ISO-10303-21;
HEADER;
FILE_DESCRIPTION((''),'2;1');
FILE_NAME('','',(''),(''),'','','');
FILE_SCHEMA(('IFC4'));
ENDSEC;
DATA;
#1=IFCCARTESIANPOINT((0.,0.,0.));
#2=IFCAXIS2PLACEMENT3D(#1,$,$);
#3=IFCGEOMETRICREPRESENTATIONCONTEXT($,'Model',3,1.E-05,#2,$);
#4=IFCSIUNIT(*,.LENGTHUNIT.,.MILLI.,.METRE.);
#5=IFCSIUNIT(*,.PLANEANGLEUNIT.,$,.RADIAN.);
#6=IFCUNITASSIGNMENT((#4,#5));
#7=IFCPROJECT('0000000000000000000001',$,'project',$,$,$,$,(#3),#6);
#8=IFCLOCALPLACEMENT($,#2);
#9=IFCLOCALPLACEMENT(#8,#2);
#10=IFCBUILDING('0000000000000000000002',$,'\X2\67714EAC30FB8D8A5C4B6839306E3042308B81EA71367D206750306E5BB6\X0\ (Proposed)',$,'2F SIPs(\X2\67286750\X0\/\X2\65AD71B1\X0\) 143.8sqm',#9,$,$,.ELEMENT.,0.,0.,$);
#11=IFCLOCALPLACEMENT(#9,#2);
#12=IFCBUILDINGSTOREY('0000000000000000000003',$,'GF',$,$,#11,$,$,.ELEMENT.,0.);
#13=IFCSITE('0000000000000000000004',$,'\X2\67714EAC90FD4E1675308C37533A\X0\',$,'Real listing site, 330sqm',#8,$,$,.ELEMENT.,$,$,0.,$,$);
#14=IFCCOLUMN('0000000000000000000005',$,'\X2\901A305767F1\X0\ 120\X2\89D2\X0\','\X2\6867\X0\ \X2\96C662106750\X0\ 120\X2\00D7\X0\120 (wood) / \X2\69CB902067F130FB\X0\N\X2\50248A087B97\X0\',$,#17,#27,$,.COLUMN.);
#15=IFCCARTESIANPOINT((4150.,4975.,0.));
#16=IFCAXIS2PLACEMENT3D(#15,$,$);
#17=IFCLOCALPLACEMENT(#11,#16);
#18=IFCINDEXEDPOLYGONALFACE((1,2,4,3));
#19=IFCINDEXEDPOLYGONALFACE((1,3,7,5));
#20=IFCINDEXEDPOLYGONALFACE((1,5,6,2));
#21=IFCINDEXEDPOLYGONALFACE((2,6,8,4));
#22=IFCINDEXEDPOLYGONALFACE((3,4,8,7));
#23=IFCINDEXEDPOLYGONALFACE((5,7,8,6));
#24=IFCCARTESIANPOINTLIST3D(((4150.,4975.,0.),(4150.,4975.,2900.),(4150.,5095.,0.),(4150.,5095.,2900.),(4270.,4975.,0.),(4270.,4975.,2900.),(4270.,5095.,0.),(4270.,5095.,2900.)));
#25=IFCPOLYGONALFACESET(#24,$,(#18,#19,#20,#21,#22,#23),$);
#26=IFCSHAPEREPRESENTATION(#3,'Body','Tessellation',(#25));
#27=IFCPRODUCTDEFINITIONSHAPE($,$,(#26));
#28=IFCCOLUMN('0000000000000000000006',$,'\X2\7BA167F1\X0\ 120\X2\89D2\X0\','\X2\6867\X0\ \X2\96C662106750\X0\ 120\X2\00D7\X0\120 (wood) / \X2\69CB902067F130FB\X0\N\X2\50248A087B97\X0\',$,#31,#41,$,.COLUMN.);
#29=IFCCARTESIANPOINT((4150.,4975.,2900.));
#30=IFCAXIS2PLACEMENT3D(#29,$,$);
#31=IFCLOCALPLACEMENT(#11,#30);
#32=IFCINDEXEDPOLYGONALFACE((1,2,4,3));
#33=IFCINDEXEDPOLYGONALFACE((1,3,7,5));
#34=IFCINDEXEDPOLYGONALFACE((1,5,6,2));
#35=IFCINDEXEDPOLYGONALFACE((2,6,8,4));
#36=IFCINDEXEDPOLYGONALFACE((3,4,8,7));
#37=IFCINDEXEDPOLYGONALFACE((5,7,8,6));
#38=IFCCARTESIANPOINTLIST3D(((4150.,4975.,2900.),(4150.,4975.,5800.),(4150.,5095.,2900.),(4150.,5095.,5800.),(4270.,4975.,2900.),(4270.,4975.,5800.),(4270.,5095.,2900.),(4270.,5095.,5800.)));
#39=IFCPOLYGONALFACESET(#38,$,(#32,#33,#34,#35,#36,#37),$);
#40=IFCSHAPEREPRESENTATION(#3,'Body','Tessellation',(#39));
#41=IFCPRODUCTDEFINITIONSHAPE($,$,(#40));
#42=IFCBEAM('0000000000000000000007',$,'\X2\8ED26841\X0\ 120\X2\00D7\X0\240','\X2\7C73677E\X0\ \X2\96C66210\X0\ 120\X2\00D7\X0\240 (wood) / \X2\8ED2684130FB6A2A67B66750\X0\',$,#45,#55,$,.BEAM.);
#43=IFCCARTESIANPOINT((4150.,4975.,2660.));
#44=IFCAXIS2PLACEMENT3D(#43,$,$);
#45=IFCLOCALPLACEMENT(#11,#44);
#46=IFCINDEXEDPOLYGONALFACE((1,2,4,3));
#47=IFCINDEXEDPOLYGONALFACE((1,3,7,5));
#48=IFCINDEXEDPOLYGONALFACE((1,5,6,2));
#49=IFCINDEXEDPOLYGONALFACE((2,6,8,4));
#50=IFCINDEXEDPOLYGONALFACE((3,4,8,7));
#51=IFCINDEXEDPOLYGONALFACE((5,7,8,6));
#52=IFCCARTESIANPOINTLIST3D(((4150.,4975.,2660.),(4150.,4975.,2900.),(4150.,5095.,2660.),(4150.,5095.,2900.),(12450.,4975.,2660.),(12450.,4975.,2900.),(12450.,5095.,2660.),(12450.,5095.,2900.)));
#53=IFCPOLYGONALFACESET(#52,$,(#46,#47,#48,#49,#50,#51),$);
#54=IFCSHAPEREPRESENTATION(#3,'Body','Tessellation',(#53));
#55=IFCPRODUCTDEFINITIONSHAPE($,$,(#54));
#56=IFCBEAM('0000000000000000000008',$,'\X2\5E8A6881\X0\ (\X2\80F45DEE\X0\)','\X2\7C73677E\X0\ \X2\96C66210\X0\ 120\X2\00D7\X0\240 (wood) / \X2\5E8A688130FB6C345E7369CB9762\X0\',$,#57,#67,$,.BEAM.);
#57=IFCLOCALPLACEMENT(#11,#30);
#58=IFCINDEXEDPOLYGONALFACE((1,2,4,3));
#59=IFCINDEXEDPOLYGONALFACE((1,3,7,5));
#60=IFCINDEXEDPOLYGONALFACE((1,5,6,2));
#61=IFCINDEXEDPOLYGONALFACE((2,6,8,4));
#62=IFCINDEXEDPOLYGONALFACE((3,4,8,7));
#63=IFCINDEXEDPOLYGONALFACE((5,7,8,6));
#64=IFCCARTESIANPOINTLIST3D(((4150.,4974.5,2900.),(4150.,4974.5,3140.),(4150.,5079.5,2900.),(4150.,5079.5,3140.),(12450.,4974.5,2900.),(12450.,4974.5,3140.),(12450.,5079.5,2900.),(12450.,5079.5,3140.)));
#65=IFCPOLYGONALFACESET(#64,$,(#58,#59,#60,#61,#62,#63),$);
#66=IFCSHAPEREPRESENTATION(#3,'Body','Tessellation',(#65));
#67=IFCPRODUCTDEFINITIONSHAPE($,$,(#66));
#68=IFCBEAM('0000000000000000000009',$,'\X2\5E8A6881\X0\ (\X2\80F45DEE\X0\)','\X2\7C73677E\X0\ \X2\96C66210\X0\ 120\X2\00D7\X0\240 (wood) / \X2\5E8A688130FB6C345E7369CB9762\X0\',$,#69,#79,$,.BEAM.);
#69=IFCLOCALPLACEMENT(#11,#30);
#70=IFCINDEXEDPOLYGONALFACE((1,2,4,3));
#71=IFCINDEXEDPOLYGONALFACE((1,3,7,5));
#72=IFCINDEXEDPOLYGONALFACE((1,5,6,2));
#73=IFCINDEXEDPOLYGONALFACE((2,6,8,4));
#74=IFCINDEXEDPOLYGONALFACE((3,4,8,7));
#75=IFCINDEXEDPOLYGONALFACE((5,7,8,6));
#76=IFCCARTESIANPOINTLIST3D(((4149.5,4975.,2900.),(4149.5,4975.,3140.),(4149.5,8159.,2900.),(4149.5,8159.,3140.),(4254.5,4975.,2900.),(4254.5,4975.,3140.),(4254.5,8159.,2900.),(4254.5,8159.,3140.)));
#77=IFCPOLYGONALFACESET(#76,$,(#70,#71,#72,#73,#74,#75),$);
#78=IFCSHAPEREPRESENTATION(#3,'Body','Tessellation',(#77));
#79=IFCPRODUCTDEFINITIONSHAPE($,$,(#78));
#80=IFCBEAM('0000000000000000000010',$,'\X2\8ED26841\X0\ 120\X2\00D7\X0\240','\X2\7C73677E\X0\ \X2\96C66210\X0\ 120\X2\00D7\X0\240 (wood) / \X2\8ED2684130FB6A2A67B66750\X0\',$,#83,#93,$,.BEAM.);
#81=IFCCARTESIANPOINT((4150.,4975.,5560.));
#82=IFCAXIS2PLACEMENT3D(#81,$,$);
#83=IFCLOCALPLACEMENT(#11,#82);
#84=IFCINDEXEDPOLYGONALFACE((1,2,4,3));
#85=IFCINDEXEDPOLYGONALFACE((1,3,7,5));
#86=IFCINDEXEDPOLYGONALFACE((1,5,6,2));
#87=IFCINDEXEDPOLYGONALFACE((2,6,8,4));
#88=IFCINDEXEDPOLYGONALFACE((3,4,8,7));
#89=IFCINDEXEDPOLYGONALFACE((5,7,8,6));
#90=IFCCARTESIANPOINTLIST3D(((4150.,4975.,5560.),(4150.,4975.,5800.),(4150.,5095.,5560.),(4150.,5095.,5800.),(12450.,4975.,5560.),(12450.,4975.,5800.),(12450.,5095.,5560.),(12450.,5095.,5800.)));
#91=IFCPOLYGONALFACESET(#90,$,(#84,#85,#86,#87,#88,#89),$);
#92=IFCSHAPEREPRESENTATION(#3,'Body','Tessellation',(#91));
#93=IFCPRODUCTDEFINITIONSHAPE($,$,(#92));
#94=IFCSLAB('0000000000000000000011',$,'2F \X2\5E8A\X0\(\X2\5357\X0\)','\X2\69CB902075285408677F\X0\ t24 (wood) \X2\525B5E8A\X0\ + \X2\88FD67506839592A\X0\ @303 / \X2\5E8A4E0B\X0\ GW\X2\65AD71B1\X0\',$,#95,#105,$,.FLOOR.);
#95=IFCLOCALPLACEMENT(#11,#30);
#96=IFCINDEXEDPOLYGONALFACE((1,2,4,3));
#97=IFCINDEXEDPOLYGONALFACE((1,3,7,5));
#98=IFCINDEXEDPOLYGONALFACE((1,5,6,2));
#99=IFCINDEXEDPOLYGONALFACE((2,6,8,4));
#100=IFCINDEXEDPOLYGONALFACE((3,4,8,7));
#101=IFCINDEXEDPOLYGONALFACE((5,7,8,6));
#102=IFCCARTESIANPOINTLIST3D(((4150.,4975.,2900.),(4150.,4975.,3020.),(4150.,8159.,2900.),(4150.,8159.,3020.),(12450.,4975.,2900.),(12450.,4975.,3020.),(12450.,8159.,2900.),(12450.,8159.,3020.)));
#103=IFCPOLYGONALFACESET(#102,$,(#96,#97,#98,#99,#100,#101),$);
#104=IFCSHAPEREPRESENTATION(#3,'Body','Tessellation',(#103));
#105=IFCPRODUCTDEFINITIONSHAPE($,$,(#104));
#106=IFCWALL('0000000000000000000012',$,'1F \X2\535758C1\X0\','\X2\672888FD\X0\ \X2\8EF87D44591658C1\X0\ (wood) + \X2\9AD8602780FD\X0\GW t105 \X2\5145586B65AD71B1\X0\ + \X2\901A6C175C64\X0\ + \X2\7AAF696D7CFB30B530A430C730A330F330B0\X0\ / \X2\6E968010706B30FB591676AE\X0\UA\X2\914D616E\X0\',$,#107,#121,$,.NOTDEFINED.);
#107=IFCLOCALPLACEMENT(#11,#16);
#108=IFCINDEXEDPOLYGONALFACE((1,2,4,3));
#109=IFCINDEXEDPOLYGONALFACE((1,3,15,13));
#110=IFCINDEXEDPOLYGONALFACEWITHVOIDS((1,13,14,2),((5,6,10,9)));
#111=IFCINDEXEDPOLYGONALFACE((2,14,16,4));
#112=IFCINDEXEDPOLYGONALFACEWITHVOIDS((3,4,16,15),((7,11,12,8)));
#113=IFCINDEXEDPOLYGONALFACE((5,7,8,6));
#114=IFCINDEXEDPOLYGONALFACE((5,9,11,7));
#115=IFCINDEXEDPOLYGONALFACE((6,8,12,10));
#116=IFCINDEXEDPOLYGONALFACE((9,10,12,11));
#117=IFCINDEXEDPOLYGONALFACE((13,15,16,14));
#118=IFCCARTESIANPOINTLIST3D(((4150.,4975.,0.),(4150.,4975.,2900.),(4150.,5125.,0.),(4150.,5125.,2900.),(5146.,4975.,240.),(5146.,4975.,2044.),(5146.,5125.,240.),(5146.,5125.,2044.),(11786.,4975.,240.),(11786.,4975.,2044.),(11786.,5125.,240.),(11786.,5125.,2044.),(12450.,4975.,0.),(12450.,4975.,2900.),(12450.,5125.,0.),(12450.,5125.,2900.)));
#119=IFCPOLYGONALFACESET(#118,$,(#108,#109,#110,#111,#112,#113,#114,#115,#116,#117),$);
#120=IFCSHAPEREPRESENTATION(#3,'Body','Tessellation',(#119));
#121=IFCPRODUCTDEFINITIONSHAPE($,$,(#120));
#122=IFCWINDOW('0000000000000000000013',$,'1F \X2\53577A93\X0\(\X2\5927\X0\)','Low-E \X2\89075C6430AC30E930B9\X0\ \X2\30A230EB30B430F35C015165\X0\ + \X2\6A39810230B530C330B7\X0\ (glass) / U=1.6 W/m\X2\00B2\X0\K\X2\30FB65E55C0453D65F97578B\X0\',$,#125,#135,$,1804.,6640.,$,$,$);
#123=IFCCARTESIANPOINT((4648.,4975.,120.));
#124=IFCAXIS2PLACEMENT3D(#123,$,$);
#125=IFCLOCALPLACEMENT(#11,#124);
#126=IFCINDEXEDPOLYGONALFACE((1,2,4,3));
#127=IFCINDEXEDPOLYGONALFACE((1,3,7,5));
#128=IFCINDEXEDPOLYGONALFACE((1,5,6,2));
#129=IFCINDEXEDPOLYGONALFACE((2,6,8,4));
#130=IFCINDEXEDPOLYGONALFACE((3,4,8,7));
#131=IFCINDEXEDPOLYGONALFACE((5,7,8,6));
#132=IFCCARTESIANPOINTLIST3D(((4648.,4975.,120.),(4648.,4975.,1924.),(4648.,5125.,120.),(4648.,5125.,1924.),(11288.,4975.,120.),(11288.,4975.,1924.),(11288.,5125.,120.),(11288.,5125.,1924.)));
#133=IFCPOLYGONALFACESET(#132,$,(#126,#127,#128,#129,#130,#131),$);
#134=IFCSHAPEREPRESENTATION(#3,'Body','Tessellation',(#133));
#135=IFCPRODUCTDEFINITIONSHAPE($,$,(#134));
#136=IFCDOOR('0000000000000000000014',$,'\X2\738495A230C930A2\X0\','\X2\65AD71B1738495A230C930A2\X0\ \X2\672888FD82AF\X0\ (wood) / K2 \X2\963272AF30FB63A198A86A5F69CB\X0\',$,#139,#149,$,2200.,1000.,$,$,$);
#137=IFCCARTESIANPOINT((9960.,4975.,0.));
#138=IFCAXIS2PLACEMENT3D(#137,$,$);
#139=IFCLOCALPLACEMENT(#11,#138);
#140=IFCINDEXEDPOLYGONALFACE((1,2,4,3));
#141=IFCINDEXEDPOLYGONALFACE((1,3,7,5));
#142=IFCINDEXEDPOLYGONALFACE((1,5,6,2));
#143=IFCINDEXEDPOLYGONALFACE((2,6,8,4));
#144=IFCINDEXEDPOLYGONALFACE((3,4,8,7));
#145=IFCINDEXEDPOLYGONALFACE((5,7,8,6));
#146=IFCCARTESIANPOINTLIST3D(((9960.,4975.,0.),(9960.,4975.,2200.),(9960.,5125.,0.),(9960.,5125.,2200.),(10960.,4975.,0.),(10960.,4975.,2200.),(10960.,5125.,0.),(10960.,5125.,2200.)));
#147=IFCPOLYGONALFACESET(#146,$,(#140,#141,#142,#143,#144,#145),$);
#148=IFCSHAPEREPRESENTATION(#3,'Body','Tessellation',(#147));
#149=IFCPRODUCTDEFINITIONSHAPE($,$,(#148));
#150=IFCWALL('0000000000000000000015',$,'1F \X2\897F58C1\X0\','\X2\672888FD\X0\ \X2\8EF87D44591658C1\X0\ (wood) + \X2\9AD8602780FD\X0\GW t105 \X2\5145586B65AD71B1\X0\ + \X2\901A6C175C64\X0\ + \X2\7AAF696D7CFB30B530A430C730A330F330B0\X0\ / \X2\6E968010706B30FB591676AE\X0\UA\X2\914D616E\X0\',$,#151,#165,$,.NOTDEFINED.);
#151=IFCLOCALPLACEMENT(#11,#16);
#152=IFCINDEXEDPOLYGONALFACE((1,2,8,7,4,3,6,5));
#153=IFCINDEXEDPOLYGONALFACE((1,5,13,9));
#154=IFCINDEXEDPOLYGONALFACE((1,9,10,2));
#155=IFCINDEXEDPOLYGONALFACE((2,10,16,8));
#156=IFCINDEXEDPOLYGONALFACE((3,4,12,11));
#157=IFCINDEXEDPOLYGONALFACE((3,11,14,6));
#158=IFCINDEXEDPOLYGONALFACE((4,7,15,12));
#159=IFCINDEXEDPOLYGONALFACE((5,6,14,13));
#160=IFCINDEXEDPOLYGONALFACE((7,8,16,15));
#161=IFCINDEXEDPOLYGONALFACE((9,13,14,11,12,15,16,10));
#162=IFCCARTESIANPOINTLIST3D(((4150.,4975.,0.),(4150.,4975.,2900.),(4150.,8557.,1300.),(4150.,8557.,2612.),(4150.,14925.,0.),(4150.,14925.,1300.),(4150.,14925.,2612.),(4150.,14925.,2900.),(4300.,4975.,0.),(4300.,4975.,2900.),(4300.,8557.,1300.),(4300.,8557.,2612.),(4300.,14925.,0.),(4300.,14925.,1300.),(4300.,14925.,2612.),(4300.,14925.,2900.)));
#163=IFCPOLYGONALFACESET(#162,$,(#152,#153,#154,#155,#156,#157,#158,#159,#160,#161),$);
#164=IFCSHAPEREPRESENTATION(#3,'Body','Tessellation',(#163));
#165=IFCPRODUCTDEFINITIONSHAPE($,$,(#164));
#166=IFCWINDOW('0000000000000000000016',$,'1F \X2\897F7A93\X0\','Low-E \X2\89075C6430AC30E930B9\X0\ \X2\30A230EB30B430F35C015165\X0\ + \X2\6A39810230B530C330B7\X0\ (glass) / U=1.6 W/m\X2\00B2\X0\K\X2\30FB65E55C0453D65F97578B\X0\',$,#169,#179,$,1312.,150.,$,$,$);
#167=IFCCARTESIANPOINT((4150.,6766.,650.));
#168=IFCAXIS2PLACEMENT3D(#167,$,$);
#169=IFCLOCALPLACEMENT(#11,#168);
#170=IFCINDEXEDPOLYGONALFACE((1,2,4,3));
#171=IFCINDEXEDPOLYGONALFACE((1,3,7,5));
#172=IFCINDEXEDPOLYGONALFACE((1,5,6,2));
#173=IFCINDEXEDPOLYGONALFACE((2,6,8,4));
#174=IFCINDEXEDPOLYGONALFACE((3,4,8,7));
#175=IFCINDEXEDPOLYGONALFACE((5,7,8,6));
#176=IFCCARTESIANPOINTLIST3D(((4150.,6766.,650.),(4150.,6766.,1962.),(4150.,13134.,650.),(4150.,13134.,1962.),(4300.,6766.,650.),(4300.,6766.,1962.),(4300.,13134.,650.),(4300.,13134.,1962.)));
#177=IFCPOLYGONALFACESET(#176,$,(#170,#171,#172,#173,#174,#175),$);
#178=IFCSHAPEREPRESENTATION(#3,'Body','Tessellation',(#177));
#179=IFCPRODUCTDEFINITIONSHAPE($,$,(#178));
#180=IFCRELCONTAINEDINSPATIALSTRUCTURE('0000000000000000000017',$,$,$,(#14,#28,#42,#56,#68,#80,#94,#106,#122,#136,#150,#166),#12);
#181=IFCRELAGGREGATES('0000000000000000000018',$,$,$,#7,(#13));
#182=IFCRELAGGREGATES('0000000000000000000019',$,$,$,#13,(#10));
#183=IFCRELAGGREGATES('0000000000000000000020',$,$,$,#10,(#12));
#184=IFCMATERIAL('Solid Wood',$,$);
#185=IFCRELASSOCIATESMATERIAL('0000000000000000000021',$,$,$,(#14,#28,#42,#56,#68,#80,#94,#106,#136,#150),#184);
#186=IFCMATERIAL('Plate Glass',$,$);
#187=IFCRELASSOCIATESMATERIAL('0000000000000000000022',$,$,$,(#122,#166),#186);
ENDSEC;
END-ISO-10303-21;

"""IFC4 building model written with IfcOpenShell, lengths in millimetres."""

from ifc_helpers import new_model, si_unit, frame, frame_2d, origin, place, context, project, spatial, rectangle, extrude, material, element, fill, save


model = new_model("IFC4")

# Units and contexts
model_context = context("Model", 3, precision=1e-05, world=origin())
ifc_project = project(units=[si_unit("LENGTHUNIT", "METRE", prefix="MILLI"), si_unit("PLANEANGLEUNIT", "RADIAN")], contexts=[model_context])

# Site, building, storey
site_placement = place(None, origin())
site = spatial("IfcSite", under=ifc_project, at=site_placement, Name="東京都世田谷区", ObjectType="Real listing site, 330sqm", CompositionType="ELEMENT", RefElevation=0.0)
building_placement = place(site_placement, origin())
building = spatial("IfcBuilding", under=site, at=building_placement, Name="東京・越屋根のある自然素材の家 (Proposed)", ObjectType="2F SIPs(木材/断熱) 143.8sqm", CompositionType="ELEMENT", ElevationOfRefHeight=0.0, ElevationOfTerrain=0.0)
storey_placement = place(building_placement, origin())
storey = spatial("IfcBuildingStorey", under=building, at=storey_placement, Name="GF", CompositionType="ELEMENT", Elevation=0.0)

# Columns
ifc_material_1 = material(Name="Solid Wood")
column_1_placement = place(storey_placement, frame((4150.0, 4975.0, 0.0)))
element("IfcColumn", 1, at=column_1_placement, inside=storey, material=ifc_material_1, Name="通し柱 120角", Description="桧 集成材 120×120 (wood) / 構造柱・N値計算", PredefinedType="COLUMN", context=model_context, shape_type="SweptSolid", body=[
    extrude(rectangle(XDim=120.0, YDim=120.0, at=frame_2d((60.0, 60.0))), frame((4150.0, 4975.0, 0.0)), (0.0, 0.0, 1.0), 2900.0),
])
column_2_placement = place(storey_placement, frame((4150.0, 4975.0, 2900.0)))
element("IfcColumn", 2, at=column_2_placement, inside=storey, material=ifc_material_1, Name="管柱 120角", Description="桧 集成材 120×120 (wood) / 構造柱・N値計算", PredefinedType="COLUMN", context=model_context, shape_type="SweptSolid", body=[
    extrude(rectangle(XDim=120.0, YDim=120.0, at=frame_2d((60.0, 60.0))), frame((4150.0, 4975.0, 2900.0)), (0.0, 0.0, 1.0), 2900.0),
])

# Beams
beam_1_placement = place(storey_placement, frame((4150.0, 4975.0, 2660.0)))
element("IfcBeam", 3, at=beam_1_placement, inside=storey, material=ifc_material_1, Name="軒桁 120×240", Description="米松 集成 120×240 (wood) / 軒桁・横架材", PredefinedType="BEAM", context=model_context, shape_type="SweptSolid", body=[
    extrude(rectangle(XDim=8300.0, YDim=120.0, at=frame_2d((4150.0, 60.0))), frame((4150.0, 4975.0, 2660.0)), (0.0, 0.0, 1.0), 240.0),
])
beam_2_placement = place(storey_placement, frame((4150.0, 4975.0, 2900.0)))
element("IfcBeam", 4, at=beam_2_placement, inside=storey, material=ifc_material_1, Name="床梁 (胴差)", Description="米松 集成 120×240 (wood) / 床梁・水平構面", PredefinedType="BEAM", context=model_context, shape_type="SweptSolid", body=[
    extrude(rectangle(XDim=8300.0, YDim=105.0, at=frame_2d((4150.0, 52.0))), frame((4150.0, 4975.0, 2900.0)), (0.0, 0.0, 1.0), 240.0),
])
beam_3_placement = place(storey_placement, frame((4150.0, 4975.0, 2900.0)))
element("IfcBeam", 5, at=beam_3_placement, inside=storey, material=ifc_material_1, Name="床梁 (胴差)", Description="米松 集成 120×240 (wood) / 床梁・水平構面", PredefinedType="BEAM", context=model_context, shape_type="SweptSolid", body=[
    extrude(rectangle(XDim=105.0, YDim=3184.0, at=frame_2d((52.0, 1592.0))), frame((4150.0, 4975.0, 2900.0)), (0.0, 0.0, 1.0), 240.0),
])
beam_4_placement = place(storey_placement, frame((4150.0, 4975.0, 5560.0)))
element("IfcBeam", 6, at=beam_4_placement, inside=storey, material=ifc_material_1, Name="軒桁 120×240", Description="米松 集成 120×240 (wood) / 軒桁・横架材", PredefinedType="BEAM", context=model_context, shape_type="SweptSolid", body=[
    extrude(rectangle(XDim=8300.0, YDim=120.0, at=frame_2d((4150.0, 60.0))), frame((4150.0, 4975.0, 5560.0)), (0.0, 0.0, 1.0), 240.0),
])

# Slab
slab_1_placement = place(storey_placement, frame((4150.0, 4975.0, 2900.0)))
element("IfcSlab", 7, at=slab_1_placement, inside=storey, material=ifc_material_1, Name="2F 床(南)", Description="構造用合板 t24 (wood) 剛床 + 製材根太 @303 / 床下 GW断熱", PredefinedType="FLOOR", context=model_context, shape_type="SweptSolid", body=[
    extrude(rectangle(XDim=8300.0, YDim=3184.0, at=frame_2d((4150.0, 1592.0))), frame((4150.0, 4975.0, 2900.0)), (0.0, 0.0, 1.0), 120.0),
])

# Wall, openings, window, door
wall_1_placement = place(storey_placement, frame((4150.0, 4975.0, 0.0)))
wall_1 = element("IfcWall", 8, at=wall_1_placement, inside=storey, material=ifc_material_1, Name="1F 南壁", Description="木製 軸組外壁 (wood) + 高性能GW t105 充填断熱 + 通気層 + 窯業系サイディング / 準耐火・外皮UA配慮", PredefinedType="NOTDEFINED", context=model_context, shape_type="SweptSolid", body=[
    extrude(rectangle(XDim=8300.0, YDim=150.0, at=frame_2d((4150.0, 75.0))), frame((4150.0, 4975.0, 0.0)), (0.0, 0.0, 1.0), 2900.0),
])
opening_1_placement = place(storey_placement, frame((4648.0, 4975.0, 120.0)))
opening_1 = element("IfcOpeningElement", 9, at=opening_1_placement, cuts=wall_1, PredefinedType="NOTDEFINED", context=model_context, shape_type="SweptSolid", body=[
    extrude(rectangle(XDim=6640.0, YDim=150.0, at=frame_2d((3320.0, 75.0))), frame((4648.0, 4975.0, 120.0)), (0.0, 0.0, 1.0), 1804.0),
])
opening_2_placement = place(storey_placement, frame((9960.0, 4975.0, 0.0)))
opening_2 = element("IfcOpeningElement", 10, at=opening_2_placement, cuts=wall_1, PredefinedType="NOTDEFINED", context=model_context, shape_type="SweptSolid", body=[
    extrude(rectangle(XDim=1000.0, YDim=150.0, at=frame_2d((500.0, 75.0))), frame((9960.0, 4975.0, 0.0)), (0.0, 0.0, 1.0), 2200.0),
])
ifc_material_2 = material(Name="Plate Glass")
window_1_placement = place(storey_placement, frame((4648.0, 4975.0, 120.0)))
window_1 = element("IfcWindow", 11, at=window_1_placement, inside=storey, material=ifc_material_2, Name="1F 南窓(大)", Description="Low-E 複層ガラス アルゴン封入 + 樹脂サッシ (glass) / U=1.6 W/m²K・日射取得型", OverallHeight=1804.0, OverallWidth=6640.0, context=model_context, shape_type="SweptSolid", body=[
    extrude(rectangle(XDim=6640.0, YDim=150.0, at=frame_2d((3320.0, 75.0))), frame((4648.0, 4975.0, 120.0)), (0.0, 0.0, 1.0), 1804.0),
])
fill(opening_1, window_1)
door_placement = place(storey_placement, frame((9960.0, 4975.0, 0.0)))
door = element("IfcDoor", 12, at=door_placement, inside=storey, material=ifc_material_1, Name="玄関ドア", Description="断熱玄関ドア 木製芯 (wood) / K2 防犯・採風機構", OverallHeight=2200.0, OverallWidth=1000.0, context=model_context, shape_type="SweptSolid", body=[
    extrude(rectangle(XDim=1000.0, YDim=150.0, at=frame_2d((500.0, 75.0))), frame((9960.0, 4975.0, 0.0)), (0.0, 0.0, 1.0), 2200.0),
])
fill(opening_2, door)

# Wall, opening, window
wall_2_placement = place(storey_placement, frame((4150.0, 4975.0, 0.0)))
wall_2 = element("IfcWall", 13, at=wall_2_placement, inside=storey, material=ifc_material_1, Name="1F 西壁", Description="木製 軸組外壁 (wood) + 高性能GW t105 充填断熱 + 通気層 + 窯業系サイディング / 準耐火・外皮UA配慮", PredefinedType="NOTDEFINED", context=model_context, shape_type="SweptSolid", body=[
    extrude(rectangle(XDim=150.0, YDim=9950.0, at=frame_2d((75.0, 4975.0))), frame((4150.0, 4975.0, 0.0)), (0.0, 0.0, 1.0), 2900.0),
])
opening_3_placement = place(storey_placement, frame((4150.0, 6766.0, 650.0)))
opening_3 = element("IfcOpeningElement", 14, at=opening_3_placement, cuts=wall_2, PredefinedType="NOTDEFINED", context=model_context, shape_type="SweptSolid", body=[
    extrude(rectangle(XDim=150.0, YDim=6368.0, at=frame_2d((75.0, 3184.0))), frame((4150.0, 6766.0, 650.0)), (0.0, 0.0, 1.0), 1312.0),
])
window_2_placement = place(storey_placement, frame((4150.0, 6766.0, 650.0)))
window_2 = element("IfcWindow", 15, at=window_2_placement, inside=storey, material=ifc_material_2, Name="1F 西窓", Description="Low-E 複層ガラス アルゴン封入 + 樹脂サッシ (glass) / U=1.6 W/m²K・日射取得型", OverallHeight=1312.0, OverallWidth=150.0, context=model_context, shape_type="SweptSolid", body=[
    extrude(rectangle(XDim=150.0, YDim=6368.0, at=frame_2d((75.0, 3184.0))), frame((4150.0, 6766.0, 650.0)), (0.0, 0.0, 1.0), 1312.0),
])
fill(opening_3, window_2)

save(model, "model.ifc")
